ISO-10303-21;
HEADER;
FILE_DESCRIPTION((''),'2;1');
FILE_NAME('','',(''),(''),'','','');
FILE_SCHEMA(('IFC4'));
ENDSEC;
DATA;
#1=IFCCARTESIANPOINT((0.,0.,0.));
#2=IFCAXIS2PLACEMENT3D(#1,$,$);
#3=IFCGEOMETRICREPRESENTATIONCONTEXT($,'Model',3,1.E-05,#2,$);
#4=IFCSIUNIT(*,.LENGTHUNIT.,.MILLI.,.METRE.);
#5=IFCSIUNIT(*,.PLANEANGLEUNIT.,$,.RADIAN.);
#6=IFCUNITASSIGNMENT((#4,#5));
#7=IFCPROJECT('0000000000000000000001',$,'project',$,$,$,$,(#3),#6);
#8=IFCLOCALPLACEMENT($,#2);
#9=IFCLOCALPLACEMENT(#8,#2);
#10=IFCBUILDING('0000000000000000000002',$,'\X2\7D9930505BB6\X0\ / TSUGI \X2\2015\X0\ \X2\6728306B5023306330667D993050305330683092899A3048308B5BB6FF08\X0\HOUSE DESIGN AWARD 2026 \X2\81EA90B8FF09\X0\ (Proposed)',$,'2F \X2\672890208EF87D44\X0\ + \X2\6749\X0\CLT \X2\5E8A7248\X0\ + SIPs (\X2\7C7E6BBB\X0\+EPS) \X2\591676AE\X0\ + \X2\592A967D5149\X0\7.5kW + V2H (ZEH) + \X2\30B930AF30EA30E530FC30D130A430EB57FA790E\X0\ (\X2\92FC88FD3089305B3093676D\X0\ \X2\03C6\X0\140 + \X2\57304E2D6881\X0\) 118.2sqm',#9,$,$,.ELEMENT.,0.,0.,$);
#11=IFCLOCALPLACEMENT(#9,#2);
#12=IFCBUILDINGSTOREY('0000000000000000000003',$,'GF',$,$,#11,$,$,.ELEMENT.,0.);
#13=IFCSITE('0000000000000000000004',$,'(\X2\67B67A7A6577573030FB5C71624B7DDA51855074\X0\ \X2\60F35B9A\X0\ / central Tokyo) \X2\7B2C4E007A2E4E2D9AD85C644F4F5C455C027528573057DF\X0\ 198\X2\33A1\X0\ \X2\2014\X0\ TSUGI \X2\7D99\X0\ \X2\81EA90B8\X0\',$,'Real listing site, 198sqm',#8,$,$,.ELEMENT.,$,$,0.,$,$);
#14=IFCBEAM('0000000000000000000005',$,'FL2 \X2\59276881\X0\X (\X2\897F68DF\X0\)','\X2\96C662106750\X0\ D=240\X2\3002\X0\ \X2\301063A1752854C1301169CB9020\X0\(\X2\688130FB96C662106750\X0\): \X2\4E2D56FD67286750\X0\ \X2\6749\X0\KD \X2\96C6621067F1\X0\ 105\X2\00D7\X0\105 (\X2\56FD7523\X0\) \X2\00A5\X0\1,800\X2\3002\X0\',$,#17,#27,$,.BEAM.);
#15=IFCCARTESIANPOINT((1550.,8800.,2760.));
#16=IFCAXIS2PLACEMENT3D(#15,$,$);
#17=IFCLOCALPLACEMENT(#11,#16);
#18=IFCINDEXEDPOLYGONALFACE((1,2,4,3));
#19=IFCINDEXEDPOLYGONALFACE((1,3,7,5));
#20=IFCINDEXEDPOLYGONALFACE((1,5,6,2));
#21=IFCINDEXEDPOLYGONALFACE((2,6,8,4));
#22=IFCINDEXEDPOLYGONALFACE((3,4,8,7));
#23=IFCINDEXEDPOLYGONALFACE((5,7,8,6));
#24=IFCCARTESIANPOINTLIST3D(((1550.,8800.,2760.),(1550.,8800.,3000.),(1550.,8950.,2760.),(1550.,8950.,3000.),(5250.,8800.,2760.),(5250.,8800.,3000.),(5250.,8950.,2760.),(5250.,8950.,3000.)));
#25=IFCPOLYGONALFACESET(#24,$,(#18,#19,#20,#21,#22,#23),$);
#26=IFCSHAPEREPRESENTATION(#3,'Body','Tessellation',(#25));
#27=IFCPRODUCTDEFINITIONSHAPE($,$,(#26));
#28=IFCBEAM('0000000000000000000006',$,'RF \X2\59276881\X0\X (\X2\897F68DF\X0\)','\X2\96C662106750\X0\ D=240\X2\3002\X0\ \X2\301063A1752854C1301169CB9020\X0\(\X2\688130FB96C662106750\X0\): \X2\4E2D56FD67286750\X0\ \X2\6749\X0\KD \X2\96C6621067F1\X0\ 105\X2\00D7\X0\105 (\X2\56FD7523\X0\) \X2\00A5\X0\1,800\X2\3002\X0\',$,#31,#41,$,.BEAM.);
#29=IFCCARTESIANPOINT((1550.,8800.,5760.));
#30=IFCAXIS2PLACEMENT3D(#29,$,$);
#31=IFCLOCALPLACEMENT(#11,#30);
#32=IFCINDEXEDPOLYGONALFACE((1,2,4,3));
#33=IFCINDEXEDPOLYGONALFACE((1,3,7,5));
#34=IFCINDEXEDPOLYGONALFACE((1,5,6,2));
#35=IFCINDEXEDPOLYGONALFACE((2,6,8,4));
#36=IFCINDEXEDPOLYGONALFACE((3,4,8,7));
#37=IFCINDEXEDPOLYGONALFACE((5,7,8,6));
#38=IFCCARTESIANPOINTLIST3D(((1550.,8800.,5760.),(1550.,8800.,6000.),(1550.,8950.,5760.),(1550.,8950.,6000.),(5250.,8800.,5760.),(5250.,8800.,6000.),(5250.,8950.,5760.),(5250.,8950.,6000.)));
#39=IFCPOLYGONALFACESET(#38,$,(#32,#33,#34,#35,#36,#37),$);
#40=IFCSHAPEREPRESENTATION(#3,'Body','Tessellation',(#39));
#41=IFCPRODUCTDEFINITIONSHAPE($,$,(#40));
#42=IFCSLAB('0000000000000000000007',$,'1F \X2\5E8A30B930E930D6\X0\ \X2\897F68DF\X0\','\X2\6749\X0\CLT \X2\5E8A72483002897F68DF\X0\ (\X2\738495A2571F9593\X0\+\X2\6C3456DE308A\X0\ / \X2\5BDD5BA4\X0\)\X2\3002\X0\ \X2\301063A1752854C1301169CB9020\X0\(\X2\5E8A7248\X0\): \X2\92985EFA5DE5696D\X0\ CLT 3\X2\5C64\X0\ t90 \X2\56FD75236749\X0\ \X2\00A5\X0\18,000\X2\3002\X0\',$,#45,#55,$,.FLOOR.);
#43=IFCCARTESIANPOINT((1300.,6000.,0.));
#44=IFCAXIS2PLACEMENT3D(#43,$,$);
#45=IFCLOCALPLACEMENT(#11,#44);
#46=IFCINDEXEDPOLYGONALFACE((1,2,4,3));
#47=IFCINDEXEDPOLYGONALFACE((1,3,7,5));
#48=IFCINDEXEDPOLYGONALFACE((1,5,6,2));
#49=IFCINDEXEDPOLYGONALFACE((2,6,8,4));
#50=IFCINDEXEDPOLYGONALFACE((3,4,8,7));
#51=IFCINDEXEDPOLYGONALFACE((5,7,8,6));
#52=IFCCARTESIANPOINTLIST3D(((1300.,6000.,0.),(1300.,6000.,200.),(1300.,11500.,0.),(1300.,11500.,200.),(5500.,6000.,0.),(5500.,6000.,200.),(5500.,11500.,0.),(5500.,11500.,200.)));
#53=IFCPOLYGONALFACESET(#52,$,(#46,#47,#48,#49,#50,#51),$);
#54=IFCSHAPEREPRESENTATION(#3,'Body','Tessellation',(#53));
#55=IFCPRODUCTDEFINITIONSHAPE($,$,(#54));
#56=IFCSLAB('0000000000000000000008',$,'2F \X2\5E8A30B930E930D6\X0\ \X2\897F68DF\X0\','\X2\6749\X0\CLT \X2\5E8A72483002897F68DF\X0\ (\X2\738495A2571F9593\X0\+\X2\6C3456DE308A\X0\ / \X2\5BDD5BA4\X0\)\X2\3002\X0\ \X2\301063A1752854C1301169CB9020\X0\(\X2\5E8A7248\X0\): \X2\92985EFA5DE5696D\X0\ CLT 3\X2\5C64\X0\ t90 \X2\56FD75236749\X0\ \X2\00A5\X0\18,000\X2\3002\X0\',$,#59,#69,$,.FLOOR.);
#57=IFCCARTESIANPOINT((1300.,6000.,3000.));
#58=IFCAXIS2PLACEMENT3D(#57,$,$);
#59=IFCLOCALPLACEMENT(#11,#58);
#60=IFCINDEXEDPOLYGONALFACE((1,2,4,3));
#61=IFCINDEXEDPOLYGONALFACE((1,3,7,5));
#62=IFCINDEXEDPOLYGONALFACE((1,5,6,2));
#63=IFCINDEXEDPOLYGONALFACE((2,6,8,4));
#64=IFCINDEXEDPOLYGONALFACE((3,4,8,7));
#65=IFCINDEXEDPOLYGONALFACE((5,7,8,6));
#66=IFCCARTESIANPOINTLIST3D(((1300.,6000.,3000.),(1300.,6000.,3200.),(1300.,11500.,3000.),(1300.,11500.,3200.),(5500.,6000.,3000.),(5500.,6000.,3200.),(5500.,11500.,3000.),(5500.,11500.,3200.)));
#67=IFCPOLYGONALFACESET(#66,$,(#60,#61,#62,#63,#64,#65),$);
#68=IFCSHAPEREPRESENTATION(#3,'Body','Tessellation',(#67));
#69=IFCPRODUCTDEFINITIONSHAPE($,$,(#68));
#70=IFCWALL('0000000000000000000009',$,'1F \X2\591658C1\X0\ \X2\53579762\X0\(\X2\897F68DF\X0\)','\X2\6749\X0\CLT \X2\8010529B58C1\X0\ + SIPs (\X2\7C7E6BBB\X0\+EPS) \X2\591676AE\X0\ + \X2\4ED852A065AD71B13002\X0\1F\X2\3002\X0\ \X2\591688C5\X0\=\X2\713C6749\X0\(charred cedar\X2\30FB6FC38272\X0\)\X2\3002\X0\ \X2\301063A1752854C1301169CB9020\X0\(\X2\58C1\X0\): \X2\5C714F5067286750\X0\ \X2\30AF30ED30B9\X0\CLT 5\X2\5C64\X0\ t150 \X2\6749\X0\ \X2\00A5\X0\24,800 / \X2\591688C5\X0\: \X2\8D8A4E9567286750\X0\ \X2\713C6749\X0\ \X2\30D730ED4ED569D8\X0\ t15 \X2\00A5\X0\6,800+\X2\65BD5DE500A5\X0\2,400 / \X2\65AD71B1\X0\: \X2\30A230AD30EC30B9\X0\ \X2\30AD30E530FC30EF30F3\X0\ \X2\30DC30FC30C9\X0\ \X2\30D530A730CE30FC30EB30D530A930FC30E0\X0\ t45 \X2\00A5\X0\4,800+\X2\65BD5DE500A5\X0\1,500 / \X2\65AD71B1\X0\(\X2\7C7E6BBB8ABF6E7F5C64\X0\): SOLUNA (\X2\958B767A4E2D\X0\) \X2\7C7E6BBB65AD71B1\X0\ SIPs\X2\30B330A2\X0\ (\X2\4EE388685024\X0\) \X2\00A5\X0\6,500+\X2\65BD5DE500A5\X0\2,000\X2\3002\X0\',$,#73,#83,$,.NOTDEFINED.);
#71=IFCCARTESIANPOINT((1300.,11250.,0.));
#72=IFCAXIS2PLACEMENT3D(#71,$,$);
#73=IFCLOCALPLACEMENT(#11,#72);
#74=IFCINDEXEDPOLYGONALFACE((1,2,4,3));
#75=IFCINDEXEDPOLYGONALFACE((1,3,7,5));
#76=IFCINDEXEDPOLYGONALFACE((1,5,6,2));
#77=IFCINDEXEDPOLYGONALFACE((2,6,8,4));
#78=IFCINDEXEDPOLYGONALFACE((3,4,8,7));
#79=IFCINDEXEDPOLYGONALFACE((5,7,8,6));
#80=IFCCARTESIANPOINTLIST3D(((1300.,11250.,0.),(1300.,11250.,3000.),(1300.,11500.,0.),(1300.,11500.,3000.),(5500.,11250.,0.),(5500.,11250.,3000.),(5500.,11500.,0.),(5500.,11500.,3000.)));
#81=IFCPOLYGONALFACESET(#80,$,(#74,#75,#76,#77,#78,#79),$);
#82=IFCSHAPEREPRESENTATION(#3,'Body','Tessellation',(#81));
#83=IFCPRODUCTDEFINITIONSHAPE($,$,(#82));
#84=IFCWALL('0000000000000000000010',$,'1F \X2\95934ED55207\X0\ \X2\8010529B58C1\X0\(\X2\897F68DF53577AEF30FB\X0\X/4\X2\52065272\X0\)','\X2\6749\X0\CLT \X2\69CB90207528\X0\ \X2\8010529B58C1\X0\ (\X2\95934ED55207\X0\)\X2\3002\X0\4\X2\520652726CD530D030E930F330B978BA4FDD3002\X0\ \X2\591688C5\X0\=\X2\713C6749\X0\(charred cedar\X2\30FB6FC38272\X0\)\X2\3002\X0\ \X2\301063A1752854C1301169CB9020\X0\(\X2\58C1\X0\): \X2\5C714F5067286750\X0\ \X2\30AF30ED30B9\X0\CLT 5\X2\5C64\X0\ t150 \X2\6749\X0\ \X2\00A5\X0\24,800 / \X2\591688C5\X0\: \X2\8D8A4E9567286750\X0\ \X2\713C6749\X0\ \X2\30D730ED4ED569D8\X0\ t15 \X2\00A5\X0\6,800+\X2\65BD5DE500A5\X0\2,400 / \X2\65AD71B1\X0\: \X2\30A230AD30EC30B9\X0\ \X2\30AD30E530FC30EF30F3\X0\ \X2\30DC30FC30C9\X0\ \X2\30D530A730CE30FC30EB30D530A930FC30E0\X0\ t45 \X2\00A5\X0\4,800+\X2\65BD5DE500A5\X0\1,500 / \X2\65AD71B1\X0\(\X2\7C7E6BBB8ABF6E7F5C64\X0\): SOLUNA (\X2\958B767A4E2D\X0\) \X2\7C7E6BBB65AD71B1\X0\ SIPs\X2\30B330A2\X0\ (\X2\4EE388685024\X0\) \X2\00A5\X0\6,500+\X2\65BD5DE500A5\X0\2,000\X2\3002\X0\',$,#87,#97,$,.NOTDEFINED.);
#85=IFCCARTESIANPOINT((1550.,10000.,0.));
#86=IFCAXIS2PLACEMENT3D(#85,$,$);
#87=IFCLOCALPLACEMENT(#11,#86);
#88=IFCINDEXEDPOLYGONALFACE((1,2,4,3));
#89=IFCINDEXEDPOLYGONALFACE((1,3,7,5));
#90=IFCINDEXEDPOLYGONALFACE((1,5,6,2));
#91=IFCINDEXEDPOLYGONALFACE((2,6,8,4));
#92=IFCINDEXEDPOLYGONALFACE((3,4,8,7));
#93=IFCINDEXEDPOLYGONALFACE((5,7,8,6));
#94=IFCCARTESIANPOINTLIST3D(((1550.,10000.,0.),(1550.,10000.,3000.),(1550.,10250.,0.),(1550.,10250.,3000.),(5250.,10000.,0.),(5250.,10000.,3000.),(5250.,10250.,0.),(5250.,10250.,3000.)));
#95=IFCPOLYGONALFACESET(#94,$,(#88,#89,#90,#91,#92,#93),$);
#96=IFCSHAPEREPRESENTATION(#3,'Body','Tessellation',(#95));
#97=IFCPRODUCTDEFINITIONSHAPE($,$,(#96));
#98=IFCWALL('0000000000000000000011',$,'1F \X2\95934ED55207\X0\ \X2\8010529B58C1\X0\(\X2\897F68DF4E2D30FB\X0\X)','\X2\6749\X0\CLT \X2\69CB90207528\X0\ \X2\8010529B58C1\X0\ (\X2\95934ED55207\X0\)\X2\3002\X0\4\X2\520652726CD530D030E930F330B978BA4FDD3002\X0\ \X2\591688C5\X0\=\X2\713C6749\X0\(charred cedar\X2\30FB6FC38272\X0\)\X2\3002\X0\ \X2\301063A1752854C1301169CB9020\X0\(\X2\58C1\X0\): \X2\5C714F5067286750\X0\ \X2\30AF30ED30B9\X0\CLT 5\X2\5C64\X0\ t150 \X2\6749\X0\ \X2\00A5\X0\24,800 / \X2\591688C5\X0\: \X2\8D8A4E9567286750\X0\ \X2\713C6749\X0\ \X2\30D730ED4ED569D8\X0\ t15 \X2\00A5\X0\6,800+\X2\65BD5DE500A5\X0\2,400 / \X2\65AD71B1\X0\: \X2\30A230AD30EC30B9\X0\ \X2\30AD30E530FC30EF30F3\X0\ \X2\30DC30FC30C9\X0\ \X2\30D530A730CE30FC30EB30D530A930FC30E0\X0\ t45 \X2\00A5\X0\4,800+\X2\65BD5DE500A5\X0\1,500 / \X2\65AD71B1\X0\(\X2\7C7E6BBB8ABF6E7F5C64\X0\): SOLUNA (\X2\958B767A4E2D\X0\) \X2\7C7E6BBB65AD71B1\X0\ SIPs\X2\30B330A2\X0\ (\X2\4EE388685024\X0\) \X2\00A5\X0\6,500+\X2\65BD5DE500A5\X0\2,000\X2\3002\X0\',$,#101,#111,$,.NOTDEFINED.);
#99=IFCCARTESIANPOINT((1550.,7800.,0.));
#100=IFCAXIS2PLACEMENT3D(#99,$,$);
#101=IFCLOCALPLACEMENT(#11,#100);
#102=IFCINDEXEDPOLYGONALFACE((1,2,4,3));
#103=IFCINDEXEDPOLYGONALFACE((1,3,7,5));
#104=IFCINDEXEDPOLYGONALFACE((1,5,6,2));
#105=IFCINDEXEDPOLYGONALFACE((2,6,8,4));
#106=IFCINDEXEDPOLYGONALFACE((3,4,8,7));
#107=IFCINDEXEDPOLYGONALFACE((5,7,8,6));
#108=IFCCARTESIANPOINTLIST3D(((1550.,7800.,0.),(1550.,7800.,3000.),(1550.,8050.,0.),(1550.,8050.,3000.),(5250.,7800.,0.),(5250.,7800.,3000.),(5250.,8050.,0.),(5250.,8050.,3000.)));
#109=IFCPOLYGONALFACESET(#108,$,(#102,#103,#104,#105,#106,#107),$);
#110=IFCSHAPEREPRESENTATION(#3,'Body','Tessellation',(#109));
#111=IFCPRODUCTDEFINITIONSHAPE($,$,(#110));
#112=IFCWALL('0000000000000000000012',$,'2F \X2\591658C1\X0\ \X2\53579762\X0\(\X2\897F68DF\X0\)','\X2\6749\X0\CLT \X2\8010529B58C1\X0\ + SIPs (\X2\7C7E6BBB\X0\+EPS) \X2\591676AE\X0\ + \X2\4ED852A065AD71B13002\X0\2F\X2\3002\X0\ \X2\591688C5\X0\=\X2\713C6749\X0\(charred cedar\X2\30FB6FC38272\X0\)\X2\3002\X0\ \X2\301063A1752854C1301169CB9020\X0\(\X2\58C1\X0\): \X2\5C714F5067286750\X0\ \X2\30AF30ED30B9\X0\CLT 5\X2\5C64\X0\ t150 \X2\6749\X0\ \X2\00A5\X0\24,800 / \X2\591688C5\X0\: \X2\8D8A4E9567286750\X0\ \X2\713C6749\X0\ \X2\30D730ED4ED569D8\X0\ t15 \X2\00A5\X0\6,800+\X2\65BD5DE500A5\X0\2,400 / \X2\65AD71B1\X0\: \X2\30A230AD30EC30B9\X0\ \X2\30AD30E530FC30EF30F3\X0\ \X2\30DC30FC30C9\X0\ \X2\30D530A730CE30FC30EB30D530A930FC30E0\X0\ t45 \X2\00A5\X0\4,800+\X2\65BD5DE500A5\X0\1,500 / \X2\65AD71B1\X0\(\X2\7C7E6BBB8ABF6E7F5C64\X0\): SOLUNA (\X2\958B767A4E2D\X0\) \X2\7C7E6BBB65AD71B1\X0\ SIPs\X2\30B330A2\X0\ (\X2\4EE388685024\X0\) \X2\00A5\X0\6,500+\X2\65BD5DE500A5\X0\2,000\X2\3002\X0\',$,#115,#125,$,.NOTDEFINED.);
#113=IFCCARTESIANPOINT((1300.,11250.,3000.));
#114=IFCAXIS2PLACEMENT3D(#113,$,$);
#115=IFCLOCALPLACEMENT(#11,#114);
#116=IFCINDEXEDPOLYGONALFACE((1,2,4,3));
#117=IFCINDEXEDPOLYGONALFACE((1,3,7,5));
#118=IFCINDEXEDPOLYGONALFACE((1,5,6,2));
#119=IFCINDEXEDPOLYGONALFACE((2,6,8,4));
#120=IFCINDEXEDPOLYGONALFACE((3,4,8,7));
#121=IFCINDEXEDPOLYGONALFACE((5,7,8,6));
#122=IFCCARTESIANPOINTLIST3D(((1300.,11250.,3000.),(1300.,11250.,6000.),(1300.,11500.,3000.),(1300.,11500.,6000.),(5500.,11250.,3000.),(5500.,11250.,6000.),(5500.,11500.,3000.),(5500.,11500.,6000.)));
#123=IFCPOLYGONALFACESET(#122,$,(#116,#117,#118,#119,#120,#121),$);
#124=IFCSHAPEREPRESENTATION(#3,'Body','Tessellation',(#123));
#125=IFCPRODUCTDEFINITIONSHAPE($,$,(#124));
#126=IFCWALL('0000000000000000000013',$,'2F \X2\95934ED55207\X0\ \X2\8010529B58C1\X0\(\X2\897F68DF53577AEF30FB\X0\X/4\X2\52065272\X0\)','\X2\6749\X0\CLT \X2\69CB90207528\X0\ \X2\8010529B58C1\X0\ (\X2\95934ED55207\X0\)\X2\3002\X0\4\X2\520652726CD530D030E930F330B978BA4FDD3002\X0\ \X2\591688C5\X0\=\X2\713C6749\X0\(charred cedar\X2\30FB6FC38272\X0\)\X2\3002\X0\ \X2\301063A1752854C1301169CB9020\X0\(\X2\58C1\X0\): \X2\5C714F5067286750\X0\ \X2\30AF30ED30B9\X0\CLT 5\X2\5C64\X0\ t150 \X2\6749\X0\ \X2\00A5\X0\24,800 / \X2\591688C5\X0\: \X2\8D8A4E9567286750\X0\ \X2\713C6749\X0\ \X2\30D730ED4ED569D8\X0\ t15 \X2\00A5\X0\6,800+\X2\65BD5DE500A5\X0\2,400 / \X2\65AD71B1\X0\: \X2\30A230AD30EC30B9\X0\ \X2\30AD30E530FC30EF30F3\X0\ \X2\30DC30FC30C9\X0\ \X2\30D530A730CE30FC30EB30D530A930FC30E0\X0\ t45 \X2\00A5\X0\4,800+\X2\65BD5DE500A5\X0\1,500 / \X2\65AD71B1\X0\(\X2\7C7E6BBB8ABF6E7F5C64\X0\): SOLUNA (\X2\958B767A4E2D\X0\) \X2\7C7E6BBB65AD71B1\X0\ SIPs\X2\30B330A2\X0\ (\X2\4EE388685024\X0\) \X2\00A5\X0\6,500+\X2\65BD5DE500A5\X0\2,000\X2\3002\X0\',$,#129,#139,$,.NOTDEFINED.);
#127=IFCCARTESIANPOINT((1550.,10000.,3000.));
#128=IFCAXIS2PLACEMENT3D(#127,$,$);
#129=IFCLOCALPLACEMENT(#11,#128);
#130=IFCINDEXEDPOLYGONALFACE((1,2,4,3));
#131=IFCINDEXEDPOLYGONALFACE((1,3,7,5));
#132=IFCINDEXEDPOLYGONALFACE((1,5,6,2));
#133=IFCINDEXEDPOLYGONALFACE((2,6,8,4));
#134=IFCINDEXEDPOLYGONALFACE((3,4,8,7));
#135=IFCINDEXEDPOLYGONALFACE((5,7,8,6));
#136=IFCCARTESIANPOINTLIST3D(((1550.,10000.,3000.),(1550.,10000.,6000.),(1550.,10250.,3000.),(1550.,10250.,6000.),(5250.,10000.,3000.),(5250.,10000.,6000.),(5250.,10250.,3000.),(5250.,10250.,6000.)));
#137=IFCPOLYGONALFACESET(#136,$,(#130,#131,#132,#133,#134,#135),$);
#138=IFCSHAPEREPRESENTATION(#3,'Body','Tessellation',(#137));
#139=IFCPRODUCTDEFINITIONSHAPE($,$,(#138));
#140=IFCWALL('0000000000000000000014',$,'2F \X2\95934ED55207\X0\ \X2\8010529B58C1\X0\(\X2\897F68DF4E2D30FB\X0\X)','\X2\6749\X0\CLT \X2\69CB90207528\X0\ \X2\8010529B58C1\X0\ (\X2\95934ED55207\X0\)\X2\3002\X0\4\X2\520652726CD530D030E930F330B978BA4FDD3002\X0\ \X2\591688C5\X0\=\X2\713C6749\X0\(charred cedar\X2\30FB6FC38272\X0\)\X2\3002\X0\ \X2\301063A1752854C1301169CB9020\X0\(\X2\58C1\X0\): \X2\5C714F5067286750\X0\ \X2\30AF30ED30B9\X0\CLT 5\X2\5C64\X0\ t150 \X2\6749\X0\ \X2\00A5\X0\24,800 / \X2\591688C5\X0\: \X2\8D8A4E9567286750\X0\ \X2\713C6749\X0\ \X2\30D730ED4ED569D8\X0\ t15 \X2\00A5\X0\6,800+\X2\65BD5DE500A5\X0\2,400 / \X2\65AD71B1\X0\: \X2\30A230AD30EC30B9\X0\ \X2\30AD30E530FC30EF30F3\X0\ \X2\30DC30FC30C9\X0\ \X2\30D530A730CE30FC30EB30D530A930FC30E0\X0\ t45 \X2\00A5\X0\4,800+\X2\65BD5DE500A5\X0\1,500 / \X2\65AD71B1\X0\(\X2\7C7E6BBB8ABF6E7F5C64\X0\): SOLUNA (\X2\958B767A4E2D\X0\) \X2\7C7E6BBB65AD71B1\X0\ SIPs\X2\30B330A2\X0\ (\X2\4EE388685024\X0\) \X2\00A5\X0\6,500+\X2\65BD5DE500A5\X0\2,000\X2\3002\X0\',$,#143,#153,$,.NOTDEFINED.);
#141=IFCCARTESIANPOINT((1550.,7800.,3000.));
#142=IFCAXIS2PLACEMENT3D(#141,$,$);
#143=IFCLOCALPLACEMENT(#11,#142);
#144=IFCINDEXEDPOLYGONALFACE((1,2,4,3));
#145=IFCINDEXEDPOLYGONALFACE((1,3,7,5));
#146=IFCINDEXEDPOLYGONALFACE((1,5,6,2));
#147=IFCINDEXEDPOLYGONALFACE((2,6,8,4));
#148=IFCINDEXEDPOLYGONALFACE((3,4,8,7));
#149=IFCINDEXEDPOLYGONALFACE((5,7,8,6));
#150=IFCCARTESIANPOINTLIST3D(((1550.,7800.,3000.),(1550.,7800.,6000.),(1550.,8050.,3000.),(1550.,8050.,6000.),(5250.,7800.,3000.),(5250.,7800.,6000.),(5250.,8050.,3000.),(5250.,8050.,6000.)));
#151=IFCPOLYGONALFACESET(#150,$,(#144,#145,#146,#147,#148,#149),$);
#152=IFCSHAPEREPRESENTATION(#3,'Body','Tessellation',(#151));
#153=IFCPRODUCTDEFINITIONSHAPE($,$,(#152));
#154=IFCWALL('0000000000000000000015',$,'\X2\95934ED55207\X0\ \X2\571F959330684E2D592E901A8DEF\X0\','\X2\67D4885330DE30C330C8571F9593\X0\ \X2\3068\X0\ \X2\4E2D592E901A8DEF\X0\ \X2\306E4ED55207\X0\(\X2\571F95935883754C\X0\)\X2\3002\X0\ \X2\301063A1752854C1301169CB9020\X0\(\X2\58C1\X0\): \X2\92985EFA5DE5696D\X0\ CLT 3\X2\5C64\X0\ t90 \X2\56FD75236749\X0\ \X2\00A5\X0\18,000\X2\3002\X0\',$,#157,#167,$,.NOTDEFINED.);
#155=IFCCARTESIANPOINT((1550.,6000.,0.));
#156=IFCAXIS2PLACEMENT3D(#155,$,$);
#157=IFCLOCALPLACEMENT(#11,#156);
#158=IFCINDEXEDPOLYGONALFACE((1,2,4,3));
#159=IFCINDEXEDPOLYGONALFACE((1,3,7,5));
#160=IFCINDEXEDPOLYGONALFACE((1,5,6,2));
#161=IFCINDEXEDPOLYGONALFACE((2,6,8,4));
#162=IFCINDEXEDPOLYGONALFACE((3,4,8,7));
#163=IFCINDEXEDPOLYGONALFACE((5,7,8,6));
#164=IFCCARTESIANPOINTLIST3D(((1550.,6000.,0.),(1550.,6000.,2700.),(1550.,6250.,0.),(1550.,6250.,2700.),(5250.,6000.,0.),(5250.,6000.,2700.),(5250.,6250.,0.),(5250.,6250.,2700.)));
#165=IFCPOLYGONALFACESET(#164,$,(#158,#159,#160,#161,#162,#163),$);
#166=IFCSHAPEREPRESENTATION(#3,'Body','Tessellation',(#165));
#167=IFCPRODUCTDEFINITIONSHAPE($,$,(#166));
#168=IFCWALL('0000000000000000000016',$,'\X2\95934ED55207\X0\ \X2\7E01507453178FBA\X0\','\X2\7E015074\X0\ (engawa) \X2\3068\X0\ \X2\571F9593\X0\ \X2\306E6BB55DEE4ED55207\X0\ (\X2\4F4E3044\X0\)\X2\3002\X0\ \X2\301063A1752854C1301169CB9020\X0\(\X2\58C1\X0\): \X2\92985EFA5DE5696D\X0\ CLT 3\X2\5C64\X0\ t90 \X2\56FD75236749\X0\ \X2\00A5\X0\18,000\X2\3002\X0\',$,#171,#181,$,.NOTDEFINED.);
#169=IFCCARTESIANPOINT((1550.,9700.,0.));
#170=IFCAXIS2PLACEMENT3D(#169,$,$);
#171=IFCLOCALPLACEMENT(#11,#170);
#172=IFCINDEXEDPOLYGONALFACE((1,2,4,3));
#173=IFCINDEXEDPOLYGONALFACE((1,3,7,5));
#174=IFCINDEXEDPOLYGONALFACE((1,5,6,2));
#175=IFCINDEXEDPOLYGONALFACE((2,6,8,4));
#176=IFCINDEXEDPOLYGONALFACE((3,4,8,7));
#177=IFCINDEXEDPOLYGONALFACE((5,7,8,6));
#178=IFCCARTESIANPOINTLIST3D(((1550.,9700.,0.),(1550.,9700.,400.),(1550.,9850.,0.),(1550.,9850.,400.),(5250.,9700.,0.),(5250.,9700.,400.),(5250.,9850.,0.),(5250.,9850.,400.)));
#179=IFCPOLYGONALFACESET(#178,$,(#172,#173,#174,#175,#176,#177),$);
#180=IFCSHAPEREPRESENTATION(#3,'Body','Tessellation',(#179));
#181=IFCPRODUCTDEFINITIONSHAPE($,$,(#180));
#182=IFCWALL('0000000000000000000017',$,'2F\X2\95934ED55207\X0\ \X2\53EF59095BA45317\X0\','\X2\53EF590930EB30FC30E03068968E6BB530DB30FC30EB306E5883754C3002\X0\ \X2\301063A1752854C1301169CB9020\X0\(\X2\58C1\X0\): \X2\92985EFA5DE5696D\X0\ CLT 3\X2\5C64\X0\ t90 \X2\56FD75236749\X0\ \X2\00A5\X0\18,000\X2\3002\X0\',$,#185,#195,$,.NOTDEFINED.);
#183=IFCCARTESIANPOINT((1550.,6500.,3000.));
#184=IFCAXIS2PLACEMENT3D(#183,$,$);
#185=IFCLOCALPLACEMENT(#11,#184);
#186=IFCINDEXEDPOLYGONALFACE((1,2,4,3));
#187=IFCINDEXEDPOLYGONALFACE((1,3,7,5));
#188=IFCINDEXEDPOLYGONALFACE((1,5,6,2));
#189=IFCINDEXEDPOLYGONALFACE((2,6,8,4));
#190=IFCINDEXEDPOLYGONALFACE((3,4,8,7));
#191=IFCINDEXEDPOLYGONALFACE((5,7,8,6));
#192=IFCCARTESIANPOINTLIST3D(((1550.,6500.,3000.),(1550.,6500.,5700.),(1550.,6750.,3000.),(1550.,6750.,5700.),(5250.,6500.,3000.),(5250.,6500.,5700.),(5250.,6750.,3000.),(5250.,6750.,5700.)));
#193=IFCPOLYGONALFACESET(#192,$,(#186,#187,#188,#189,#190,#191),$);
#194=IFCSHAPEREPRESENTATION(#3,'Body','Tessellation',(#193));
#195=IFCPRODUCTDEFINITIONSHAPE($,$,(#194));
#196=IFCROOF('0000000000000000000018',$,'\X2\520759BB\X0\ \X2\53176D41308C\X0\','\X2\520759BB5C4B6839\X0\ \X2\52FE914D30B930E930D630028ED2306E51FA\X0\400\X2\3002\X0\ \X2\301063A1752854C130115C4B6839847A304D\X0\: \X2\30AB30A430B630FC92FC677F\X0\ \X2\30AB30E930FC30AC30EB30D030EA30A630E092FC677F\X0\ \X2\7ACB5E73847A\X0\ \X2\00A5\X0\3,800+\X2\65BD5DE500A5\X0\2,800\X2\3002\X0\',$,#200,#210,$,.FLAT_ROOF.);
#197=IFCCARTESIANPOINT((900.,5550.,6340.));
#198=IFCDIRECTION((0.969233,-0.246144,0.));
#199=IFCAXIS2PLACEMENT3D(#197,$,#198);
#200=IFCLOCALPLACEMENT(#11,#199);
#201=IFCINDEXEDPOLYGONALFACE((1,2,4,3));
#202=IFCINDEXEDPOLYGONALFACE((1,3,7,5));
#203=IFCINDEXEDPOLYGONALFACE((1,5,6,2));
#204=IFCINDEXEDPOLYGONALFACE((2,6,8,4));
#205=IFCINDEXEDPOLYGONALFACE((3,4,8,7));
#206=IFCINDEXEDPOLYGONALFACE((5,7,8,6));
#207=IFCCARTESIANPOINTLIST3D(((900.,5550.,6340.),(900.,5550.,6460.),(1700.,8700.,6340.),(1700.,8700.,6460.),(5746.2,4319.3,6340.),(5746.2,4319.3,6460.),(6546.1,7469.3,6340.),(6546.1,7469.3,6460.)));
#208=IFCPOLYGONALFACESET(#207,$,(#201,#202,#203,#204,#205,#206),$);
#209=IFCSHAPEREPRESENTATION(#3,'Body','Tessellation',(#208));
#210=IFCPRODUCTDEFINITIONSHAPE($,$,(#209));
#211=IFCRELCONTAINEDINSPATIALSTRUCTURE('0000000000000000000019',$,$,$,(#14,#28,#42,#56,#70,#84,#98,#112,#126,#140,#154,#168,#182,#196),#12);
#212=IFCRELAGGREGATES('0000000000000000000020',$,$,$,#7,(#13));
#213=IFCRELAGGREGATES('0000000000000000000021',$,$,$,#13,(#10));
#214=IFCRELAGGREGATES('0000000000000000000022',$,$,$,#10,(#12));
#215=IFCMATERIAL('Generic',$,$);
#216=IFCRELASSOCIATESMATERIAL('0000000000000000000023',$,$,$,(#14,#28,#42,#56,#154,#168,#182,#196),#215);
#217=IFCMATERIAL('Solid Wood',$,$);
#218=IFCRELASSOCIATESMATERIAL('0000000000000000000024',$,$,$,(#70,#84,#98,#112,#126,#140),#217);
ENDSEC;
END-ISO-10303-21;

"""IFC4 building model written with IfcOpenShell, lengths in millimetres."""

from ifc_helpers import new_model, si_unit, frame, frame_2d, origin, place, context, project, spatial, rectangle, extrude, material, element, save


model = new_model("IFC4")

# Units and contexts
model_context = context("Model", 3, precision=1e-05, world=origin())
ifc_project = project(units=[si_unit("LENGTHUNIT", "METRE", prefix="MILLI"), si_unit("PLANEANGLEUNIT", "RADIAN")], contexts=[model_context])

# Site, building, storey
site_placement = place(None, origin())
site = spatial("IfcSite", under=ifc_project, at=site_placement, Name="(架空敷地・山手線内側 想定 / central Tokyo) 第一種中高層住居専用地域 198㎡ — TSUGI 継 自邸", ObjectType="Real listing site, 198sqm", CompositionType="ELEMENT", RefElevation=0.0)
building_placement = place(site_placement, origin())
building = spatial("IfcBuilding", under=site, at=building_placement, Name="継ぐ家 / TSUGI ― 木に倣って継ぐことを覚える家（HOUSE DESIGN AWARD 2026 自邸） (Proposed)", ObjectType="2F 木造軸組 + 杉CLT 床版 + SIPs (籾殻+EPS) 外皮 + 太陽光7.5kW + V2H (ZEH) + スクリューパイル基礎 (鋼製らせん杭 φ140 + 地中梁) 118.2sqm", CompositionType="ELEMENT", ElevationOfRefHeight=0.0, ElevationOfTerrain=0.0)
storey_placement = place(building_placement, origin())
storey = spatial("IfcBuildingStorey", under=building, at=storey_placement, Name="GF", CompositionType="ELEMENT", Elevation=0.0)

# Beams
ifc_material_1 = material(Name="Generic")
beam_1_placement = place(storey_placement, frame((1550.0, 8800.0, 2760.0)))
element("IfcBeam", 1, at=beam_1_placement, inside=storey, material=ifc_material_1, Name="FL2 大梁X (西棟)", Description="集成材 D=240。 【採用品】構造(梁・集成材): 中国木材 杉KD 集成柱 105×105 (国産) ¥1,800。", PredefinedType="BEAM", context=model_context, shape_type="SweptSolid", body=[
    extrude(rectangle(XDim=3700.0, YDim=150.0, at=frame_2d((1850.0, 75.0))), frame((1550.0, 8800.0, 2760.0)), (0.0, 0.0, 1.0), 240.0),
])
beam_2_placement = place(storey_placement, frame((1550.0, 8800.0, 5760.0)))
element("IfcBeam", 2, at=beam_2_placement, inside=storey, material=ifc_material_1, Name="RF 大梁X (西棟)", Description="集成材 D=240。 【採用品】構造(梁・集成材): 中国木材 杉KD 集成柱 105×105 (国産) ¥1,800。", PredefinedType="BEAM", context=model_context, shape_type="SweptSolid", body=[
    extrude(rectangle(XDim=3700.0, YDim=150.0, at=frame_2d((1850.0, 75.0))), frame((1550.0, 8800.0, 5760.0)), (0.0, 0.0, 1.0), 240.0),
])

# Slabs
slab_1_placement = place(storey_placement, frame((1300.0, 6000.0, 0.0)))
element("IfcSlab", 3, at=slab_1_placement, inside=storey, material=ifc_material_1, Name="1F 床スラブ 西棟", Description="杉CLT 床版。西棟 (玄関土間+水回り / 寝室)。 【採用品】構造(床版): 銘建工業 CLT 3層 t90 国産杉 ¥18,000。", PredefinedType="FLOOR", context=model_context, shape_type="SweptSolid", body=[
    extrude(rectangle(XDim=4200.0, YDim=5500.0, at=frame_2d((2100.0, 2750.0))), frame((1300.0, 6000.0, 0.0)), (0.0, 0.0, 1.0), 200.0),
])
slab_2_placement = place(storey_placement, frame((1300.0, 6000.0, 3000.0)))
element("IfcSlab", 4, at=slab_2_placement, inside=storey, material=ifc_material_1, Name="2F 床スラブ 西棟", Description="杉CLT 床版。西棟 (玄関土間+水回り / 寝室)。 【採用品】構造(床版): 銘建工業 CLT 3層 t90 国産杉 ¥18,000。", PredefinedType="FLOOR", context=model_context, shape_type="SweptSolid", body=[
    extrude(rectangle(XDim=4200.0, YDim=5500.0, at=frame_2d((2100.0, 2750.0))), frame((1300.0, 6000.0, 3000.0)), (0.0, 0.0, 1.0), 200.0),
])

# Walls
ifc_material_2 = material(Name="Solid Wood")
wall_1_placement = place(storey_placement, frame((1300.0, 11250.0, 0.0)))
element("IfcWall", 5, at=wall_1_placement, inside=storey, material=ifc_material_2, Name="1F 外壁 南面(西棟)", Description="杉CLT 耐力壁 + SIPs (籾殻+EPS) 外皮 + 付加断熱。1F。 外装=焼杉(charred cedar・濃色)。 【採用品】構造(壁): 山佐木材 クロスCLT 5層 t150 杉 ¥24,800 / 外装: 越井木材 焼杉 プロ仕様 t15 ¥6,800+施工¥2,400 / 断熱: アキレス キューワン ボード フェノールフォーム t45 ¥4,800+施工¥1,500 / 断熱(籾殻調湿層): SOLUNA (開発中) 籾殻断熱 SIPsコア (代表値) ¥6,500+施工¥2,000。", PredefinedType="NOTDEFINED", context=model_context, shape_type="SweptSolid", body=[
    extrude(rectangle(XDim=4200.0, YDim=250.0, at=frame_2d((2100.0, 125.0))), frame((1300.0, 11250.0, 0.0)), (0.0, 0.0, 1.0), 3000.0),
])
wall_2_placement = place(storey_placement, frame((1550.0, 10000.0, 0.0)))
element("IfcWall", 6, at=wall_2_placement, inside=storey, material=ifc_material_2, Name="1F 間仕切 耐力壁(西棟南端・X/4分割)", Description="杉CLT 構造用 耐力壁 (間仕切)。4分割法バランス確保。 外装=焼杉(charred cedar・濃色)。 【採用品】構造(壁): 山佐木材 クロスCLT 5層 t150 杉 ¥24,800 / 外装: 越井木材 焼杉 プロ仕様 t15 ¥6,800+施工¥2,400 / 断熱: アキレス キューワン ボード フェノールフォーム t45 ¥4,800+施工¥1,500 / 断熱(籾殻調湿層): SOLUNA (開発中) 籾殻断熱 SIPsコア (代表値) ¥6,500+施工¥2,000。", PredefinedType="NOTDEFINED", context=model_context, shape_type="SweptSolid", body=[
    extrude(rectangle(XDim=3700.0, YDim=250.0, at=frame_2d((1850.0, 125.0))), frame((1550.0, 10000.0, 0.0)), (0.0, 0.0, 1.0), 3000.0),
])
wall_3_placement = place(storey_placement, frame((1550.0, 7800.0, 0.0)))
element("IfcWall", 7, at=wall_3_placement, inside=storey, material=ifc_material_2, Name="1F 間仕切 耐力壁(西棟中・X)", Description="杉CLT 構造用 耐力壁 (間仕切)。4分割法バランス確保。 外装=焼杉(charred cedar・濃色)。 【採用品】構造(壁): 山佐木材 クロスCLT 5層 t150 杉 ¥24,800 / 外装: 越井木材 焼杉 プロ仕様 t15 ¥6,800+施工¥2,400 / 断熱: アキレス キューワン ボード フェノールフォーム t45 ¥4,800+施工¥1,500 / 断熱(籾殻調湿層): SOLUNA (開発中) 籾殻断熱 SIPsコア (代表値) ¥6,500+施工¥2,000。", PredefinedType="NOTDEFINED", context=model_context, shape_type="SweptSolid", body=[
    extrude(rectangle(XDim=3700.0, YDim=250.0, at=frame_2d((1850.0, 125.0))), frame((1550.0, 7800.0, 0.0)), (0.0, 0.0, 1.0), 3000.0),
])
wall_4_placement = place(storey_placement, frame((1300.0, 11250.0, 3000.0)))
element("IfcWall", 8, at=wall_4_placement, inside=storey, material=ifc_material_2, Name="2F 外壁 南面(西棟)", Description="杉CLT 耐力壁 + SIPs (籾殻+EPS) 外皮 + 付加断熱。2F。 外装=焼杉(charred cedar・濃色)。 【採用品】構造(壁): 山佐木材 クロスCLT 5層 t150 杉 ¥24,800 / 外装: 越井木材 焼杉 プロ仕様 t15 ¥6,800+施工¥2,400 / 断熱: アキレス キューワン ボード フェノールフォーム t45 ¥4,800+施工¥1,500 / 断熱(籾殻調湿層): SOLUNA (開発中) 籾殻断熱 SIPsコア (代表値) ¥6,500+施工¥2,000。", PredefinedType="NOTDEFINED", context=model_context, shape_type="SweptSolid", body=[
    extrude(rectangle(XDim=4200.0, YDim=250.0, at=frame_2d((2100.0, 125.0))), frame((1300.0, 11250.0, 3000.0)), (0.0, 0.0, 1.0), 3000.0),
])
wall_5_placement = place(storey_placement, frame((1550.0, 10000.0, 3000.0)))
element("IfcWall", 9, at=wall_5_placement, inside=storey, material=ifc_material_2, Name="2F 間仕切 耐力壁(西棟南端・X/4分割)", Description="杉CLT 構造用 耐力壁 (間仕切)。4分割法バランス確保。 外装=焼杉(charred cedar・濃色)。 【採用品】構造(壁): 山佐木材 クロスCLT 5層 t150 杉 ¥24,800 / 外装: 越井木材 焼杉 プロ仕様 t15 ¥6,800+施工¥2,400 / 断熱: アキレス キューワン ボード フェノールフォーム t45 ¥4,800+施工¥1,500 / 断熱(籾殻調湿層): SOLUNA (開発中) 籾殻断熱 SIPsコア (代表値) ¥6,500+施工¥2,000。", PredefinedType="NOTDEFINED", context=model_context, shape_type="SweptSolid", body=[
    extrude(rectangle(XDim=3700.0, YDim=250.0, at=frame_2d((1850.0, 125.0))), frame((1550.0, 10000.0, 3000.0)), (0.0, 0.0, 1.0), 3000.0),
])
wall_6_placement = place(storey_placement, frame((1550.0, 7800.0, 3000.0)))
element("IfcWall", 10, at=wall_6_placement, inside=storey, material=ifc_material_2, Name="2F 間仕切 耐力壁(西棟中・X)", Description="杉CLT 構造用 耐力壁 (間仕切)。4分割法バランス確保。 外装=焼杉(charred cedar・濃色)。 【採用品】構造(壁): 山佐木材 クロスCLT 5層 t150 杉 ¥24,800 / 外装: 越井木材 焼杉 プロ仕様 t15 ¥6,800+施工¥2,400 / 断熱: アキレス キューワン ボード フェノールフォーム t45 ¥4,800+施工¥1,500 / 断熱(籾殻調湿層): SOLUNA (開発中) 籾殻断熱 SIPsコア (代表値) ¥6,500+施工¥2,000。", PredefinedType="NOTDEFINED", context=model_context, shape_type="SweptSolid", body=[
    extrude(rectangle(XDim=3700.0, YDim=250.0, at=frame_2d((1850.0, 125.0))), frame((1550.0, 7800.0, 3000.0)), (0.0, 0.0, 1.0), 3000.0),
])
wall_7_placement = place(storey_placement, frame((1550.0, 6000.0, 0.0)))
element("IfcWall", 11, at=wall_7_placement, inside=storey, material=ifc_material_1, Name="間仕切 土間と中央通路", Description="柔術マット土間 と 中央通路 の仕切(土間境界)。 【採用品】構造(壁): 銘建工業 CLT 3層 t90 国産杉 ¥18,000。", PredefinedType="NOTDEFINED", context=model_context, shape_type="SweptSolid", body=[
    extrude(rectangle(XDim=3700.0, YDim=250.0, at=frame_2d((1850.0, 125.0))), frame((1550.0, 6000.0, 0.0)), (0.0, 0.0, 1.0), 2700.0),
])
wall_8_placement = place(storey_placement, frame((1550.0, 9700.0, 0.0)))
element("IfcWall", 12, at=wall_8_placement, inside=storey, material=ifc_material_1, Name="間仕切 縁側北辺", Description="縁側 (engawa) と 土間 の段差仕切 (低い)。 【採用品】構造(壁): 銘建工業 CLT 3層 t90 国産杉 ¥18,000。", PredefinedType="NOTDEFINED", context=model_context, shape_type="SweptSolid", body=[
    extrude(rectangle(XDim=3700.0, YDim=150.0, at=frame_2d((1850.0, 75.0))), frame((1550.0, 9700.0, 0.0)), (0.0, 0.0, 1.0), 400.0),
])
wall_9_placement = place(storey_placement, frame((1550.0, 6500.0, 3000.0)))
element("IfcWall", 13, at=wall_9_placement, inside=storey, material=ifc_material_1, Name="2F間仕切 可変室北", Description="可変ルームと階段ホールの境界。 【採用品】構造(壁): 銘建工業 CLT 3層 t90 国産杉 ¥18,000。", PredefinedType="NOTDEFINED", context=model_context, shape_type="SweptSolid", body=[
    extrude(rectangle(XDim=3700.0, YDim=250.0, at=frame_2d((1850.0, 125.0))), frame((1550.0, 6500.0, 3000.0)), (0.0, 0.0, 1.0), 2700.0),
])

# Roof
roof_1_placement = place(storey_placement, frame((900.0, 5550.0, 6340.0), x_axis=(0.969233, -0.246144, 0.0)))
element("IfcRoof", 14, at=roof_1_placement, inside=storey, material=ifc_material_1, Name="切妻 北流れ", Description="切妻屋根 勾配スラブ。軒の出400。 【採用品】屋根葺き: カイザー鋼板 カラーガルバリウム鋼板 立平葺 ¥3,800+施工¥2,800。", PredefinedType="FLAT_ROOF", context=model_context, shape_type="SweptSolid", body=[
    extrude(rectangle(XDim=5000.0, YDim=3250.0, at=frame_2d((2500.0, 1625.0))), frame((900.0, 5550.0, 6340.0), x_axis=(0.969233, -0.246144, 0.0)), (0.0, 0.0, 1.0), 120.0),
])

save(model, "model.ifc")
